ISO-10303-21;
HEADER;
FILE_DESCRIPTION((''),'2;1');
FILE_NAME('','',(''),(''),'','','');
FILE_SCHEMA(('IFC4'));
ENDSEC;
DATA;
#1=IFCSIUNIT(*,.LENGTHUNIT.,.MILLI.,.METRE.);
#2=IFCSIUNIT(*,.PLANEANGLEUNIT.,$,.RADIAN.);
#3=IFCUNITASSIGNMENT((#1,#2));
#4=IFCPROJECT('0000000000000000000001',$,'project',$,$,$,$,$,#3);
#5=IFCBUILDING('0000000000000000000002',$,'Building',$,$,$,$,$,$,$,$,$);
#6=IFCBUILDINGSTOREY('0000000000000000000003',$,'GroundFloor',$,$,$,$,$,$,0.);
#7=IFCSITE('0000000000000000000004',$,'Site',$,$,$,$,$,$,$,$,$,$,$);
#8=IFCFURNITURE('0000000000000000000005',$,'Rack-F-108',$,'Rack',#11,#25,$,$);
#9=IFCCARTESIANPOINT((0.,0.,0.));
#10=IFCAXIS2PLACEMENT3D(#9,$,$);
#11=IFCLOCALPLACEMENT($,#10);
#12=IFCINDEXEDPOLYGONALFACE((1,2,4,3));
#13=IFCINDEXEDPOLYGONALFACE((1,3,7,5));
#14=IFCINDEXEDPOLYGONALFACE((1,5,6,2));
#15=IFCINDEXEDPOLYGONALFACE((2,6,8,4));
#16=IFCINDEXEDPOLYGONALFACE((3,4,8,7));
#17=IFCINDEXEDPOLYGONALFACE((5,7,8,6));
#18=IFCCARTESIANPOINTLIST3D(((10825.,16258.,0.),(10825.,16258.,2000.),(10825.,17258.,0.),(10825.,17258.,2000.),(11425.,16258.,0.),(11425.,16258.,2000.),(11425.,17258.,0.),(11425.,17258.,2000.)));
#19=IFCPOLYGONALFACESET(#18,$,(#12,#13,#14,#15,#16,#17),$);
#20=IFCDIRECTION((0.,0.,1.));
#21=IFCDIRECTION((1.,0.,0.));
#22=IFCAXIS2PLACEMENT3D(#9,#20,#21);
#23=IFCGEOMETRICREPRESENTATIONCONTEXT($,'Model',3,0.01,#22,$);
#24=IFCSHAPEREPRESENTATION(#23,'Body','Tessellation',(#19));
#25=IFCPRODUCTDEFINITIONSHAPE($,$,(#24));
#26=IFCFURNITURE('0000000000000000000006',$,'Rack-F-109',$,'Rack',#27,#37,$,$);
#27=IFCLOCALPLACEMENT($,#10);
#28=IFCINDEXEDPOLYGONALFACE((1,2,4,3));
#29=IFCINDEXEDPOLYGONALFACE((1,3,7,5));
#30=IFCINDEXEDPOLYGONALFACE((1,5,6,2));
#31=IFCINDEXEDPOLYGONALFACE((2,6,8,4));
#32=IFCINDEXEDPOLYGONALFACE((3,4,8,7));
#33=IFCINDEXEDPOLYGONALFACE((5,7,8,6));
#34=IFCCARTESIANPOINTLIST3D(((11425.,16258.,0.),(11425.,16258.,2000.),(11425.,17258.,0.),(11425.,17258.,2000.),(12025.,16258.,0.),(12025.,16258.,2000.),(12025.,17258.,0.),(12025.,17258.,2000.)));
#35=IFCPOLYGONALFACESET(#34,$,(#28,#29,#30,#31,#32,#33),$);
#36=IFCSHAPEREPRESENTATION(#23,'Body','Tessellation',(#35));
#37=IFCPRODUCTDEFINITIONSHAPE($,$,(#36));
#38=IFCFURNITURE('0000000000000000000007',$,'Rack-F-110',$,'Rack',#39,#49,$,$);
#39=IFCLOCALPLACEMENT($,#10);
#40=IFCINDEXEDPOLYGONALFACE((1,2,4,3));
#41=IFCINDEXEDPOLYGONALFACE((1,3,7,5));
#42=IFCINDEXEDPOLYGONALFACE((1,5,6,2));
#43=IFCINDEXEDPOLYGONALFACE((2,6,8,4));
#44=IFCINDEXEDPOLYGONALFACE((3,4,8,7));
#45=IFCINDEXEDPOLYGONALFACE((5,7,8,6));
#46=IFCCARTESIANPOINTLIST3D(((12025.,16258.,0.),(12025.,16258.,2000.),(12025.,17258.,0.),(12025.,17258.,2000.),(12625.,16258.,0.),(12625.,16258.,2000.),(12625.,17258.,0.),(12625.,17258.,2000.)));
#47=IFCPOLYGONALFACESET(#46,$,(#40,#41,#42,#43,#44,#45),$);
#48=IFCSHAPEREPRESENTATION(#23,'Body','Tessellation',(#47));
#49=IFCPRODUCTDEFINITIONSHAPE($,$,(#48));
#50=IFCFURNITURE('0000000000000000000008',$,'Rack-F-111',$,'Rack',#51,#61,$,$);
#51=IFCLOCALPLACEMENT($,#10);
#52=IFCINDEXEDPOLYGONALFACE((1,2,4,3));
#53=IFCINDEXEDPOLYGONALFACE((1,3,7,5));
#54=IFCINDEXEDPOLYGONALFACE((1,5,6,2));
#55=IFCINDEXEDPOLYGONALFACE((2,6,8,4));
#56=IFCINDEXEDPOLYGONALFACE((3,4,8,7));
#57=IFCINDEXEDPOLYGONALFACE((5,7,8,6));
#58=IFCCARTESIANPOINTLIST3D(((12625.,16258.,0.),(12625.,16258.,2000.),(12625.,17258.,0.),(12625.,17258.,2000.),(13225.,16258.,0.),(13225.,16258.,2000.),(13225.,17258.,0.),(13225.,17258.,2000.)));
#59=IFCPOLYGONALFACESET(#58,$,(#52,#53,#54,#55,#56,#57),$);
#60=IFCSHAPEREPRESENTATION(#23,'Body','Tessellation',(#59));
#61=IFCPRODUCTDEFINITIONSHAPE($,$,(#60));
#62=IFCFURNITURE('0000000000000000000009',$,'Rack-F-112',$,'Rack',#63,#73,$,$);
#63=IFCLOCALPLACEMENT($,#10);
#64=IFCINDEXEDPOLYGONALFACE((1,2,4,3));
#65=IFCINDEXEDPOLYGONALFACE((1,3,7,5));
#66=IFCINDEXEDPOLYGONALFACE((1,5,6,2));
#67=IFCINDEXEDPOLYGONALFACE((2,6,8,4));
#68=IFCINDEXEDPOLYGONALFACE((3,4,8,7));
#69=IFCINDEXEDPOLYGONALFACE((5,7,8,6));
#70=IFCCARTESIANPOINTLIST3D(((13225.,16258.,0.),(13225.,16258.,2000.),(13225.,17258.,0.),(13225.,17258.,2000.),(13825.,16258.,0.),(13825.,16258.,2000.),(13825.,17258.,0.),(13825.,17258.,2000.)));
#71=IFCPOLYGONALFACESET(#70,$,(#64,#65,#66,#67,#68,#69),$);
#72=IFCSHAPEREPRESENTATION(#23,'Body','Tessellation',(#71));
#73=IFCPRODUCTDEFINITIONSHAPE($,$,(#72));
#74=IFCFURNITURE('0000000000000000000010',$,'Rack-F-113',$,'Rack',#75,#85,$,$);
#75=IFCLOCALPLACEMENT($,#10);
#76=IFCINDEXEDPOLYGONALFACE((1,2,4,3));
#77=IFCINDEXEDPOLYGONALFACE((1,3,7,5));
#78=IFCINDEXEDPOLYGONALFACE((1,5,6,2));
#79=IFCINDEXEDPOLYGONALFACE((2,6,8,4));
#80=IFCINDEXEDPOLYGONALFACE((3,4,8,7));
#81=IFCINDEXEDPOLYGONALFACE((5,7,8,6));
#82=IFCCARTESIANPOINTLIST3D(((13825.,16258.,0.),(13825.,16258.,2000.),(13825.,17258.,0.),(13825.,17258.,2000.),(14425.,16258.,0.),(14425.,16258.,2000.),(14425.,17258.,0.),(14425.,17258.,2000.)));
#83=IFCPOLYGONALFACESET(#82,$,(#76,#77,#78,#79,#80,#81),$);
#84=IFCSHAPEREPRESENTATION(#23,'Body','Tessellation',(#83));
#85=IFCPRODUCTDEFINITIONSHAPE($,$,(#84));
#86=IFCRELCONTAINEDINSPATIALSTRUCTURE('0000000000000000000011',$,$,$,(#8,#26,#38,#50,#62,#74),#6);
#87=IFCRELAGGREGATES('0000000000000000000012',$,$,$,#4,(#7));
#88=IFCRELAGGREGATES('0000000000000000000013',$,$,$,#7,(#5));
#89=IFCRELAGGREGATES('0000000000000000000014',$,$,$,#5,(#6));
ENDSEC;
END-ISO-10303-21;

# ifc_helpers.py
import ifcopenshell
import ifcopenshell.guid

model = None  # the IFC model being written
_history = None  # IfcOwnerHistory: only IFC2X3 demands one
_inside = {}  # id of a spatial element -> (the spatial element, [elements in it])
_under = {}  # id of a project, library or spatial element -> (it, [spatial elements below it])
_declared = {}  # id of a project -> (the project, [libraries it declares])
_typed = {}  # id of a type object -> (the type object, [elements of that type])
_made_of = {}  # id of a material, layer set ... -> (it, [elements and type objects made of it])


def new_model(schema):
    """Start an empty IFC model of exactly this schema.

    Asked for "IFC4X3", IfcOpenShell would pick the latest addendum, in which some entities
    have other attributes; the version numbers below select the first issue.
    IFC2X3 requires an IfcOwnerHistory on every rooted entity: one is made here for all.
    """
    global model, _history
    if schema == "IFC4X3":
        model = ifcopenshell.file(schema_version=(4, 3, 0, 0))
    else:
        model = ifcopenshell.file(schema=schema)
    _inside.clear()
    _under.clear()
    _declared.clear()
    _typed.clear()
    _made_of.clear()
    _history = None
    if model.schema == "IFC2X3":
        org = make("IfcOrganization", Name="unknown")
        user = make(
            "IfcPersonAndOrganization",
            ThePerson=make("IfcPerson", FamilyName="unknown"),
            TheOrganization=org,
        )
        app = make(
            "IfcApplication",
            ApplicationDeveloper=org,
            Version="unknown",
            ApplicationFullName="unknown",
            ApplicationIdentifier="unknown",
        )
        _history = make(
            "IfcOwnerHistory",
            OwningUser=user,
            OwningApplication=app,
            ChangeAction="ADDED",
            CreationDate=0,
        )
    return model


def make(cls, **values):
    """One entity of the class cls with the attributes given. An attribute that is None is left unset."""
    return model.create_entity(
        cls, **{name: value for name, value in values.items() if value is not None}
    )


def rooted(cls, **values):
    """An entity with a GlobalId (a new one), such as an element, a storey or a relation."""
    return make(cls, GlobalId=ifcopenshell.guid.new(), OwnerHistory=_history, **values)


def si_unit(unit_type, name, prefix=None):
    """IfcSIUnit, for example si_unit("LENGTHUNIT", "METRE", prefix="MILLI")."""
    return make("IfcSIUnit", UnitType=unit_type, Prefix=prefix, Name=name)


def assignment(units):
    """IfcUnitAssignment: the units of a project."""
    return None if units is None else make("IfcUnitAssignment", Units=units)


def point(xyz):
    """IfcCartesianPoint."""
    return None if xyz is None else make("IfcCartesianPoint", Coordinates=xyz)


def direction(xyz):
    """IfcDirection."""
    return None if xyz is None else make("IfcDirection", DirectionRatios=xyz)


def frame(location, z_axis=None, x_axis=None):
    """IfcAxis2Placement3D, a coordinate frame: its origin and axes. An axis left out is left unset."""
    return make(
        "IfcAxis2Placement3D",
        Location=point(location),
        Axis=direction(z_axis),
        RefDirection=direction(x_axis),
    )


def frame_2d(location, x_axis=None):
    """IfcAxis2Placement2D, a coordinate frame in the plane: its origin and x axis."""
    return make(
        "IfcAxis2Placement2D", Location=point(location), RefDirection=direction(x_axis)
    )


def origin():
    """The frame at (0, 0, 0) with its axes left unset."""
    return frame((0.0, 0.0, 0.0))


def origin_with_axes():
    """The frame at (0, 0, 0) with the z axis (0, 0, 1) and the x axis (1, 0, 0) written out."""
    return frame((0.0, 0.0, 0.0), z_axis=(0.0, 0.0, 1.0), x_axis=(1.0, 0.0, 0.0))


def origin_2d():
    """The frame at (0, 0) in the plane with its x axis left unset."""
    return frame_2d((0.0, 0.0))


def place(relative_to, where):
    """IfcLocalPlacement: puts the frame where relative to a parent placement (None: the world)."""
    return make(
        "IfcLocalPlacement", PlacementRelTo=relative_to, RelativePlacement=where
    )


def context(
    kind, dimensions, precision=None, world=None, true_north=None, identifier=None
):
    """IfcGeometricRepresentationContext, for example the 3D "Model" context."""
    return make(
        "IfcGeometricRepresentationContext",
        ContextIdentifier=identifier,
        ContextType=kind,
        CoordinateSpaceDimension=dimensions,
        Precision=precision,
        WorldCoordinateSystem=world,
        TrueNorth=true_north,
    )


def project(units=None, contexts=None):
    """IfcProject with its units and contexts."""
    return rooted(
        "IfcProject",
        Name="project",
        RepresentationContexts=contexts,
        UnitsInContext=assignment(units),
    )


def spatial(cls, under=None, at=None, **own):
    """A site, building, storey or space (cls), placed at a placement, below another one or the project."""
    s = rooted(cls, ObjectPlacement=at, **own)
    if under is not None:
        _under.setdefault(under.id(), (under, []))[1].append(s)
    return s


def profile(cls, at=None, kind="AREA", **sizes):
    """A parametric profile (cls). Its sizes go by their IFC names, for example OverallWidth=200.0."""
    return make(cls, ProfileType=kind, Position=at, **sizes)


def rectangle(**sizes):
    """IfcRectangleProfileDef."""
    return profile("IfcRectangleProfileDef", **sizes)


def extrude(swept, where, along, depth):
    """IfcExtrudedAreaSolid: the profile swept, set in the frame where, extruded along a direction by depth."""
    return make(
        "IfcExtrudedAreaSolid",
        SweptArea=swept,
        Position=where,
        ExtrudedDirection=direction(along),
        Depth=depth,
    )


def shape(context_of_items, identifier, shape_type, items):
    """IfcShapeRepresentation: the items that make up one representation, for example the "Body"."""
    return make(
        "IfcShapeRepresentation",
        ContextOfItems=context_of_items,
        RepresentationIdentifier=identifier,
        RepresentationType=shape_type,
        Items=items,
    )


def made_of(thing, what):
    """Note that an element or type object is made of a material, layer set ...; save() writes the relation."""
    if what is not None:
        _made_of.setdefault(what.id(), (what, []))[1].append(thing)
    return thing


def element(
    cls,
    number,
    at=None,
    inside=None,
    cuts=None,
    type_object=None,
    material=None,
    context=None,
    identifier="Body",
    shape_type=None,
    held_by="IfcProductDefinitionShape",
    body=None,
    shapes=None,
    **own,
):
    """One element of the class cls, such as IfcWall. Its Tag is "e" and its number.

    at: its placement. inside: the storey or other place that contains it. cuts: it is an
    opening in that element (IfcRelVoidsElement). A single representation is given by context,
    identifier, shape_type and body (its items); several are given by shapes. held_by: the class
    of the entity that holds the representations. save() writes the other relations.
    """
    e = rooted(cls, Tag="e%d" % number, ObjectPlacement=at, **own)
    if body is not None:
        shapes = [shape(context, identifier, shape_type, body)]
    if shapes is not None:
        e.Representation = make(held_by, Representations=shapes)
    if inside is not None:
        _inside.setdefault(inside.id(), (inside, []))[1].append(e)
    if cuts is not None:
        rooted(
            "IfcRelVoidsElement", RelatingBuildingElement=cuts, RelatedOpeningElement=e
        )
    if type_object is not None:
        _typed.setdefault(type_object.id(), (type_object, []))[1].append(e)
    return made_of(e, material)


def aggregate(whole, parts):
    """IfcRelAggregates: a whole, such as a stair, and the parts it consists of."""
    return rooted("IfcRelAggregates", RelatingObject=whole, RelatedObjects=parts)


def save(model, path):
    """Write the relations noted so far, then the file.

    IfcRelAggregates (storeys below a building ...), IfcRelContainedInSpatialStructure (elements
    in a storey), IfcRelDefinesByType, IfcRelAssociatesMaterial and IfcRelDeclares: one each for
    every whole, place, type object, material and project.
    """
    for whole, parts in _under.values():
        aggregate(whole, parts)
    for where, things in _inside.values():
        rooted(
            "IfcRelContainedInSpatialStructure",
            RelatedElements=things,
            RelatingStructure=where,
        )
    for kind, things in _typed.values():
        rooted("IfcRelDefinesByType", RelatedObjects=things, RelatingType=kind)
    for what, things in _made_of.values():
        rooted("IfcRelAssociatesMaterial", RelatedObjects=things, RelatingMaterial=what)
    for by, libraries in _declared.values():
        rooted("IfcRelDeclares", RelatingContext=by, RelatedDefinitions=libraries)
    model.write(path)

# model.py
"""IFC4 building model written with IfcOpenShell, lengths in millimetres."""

from ifc_helpers import new_model, si_unit, frame, origin, origin_with_axes, origin_2d, place, context, project, spatial, rectangle, extrude, element, save


model = new_model("IFC4")

# Units and contexts
model_context = context("Model", 3, precision=0.01, world=origin_with_axes())
ifc_project = project(units=[si_unit("LENGTHUNIT", "METRE", prefix="MILLI"), si_unit("PLANEANGLEUNIT", "RADIAN")])

# Site, building, storey
site = spatial("IfcSite", under=ifc_project, Name="Site")
building = spatial("IfcBuilding", under=site, Name="Building")
storey = spatial("IfcBuildingStorey", under=building, Name="GroundFloor", Elevation=0.0)

# Furniture
for number, where, z_axis, x_axis, name in (
    (1, (11125.0, 16758.0, 0.0), (0.0, 0.0, 1.0), (1.0, 0.0, 0.0), "Rack-F-108"),
    (2, (11725.0, 16758.0, 0.0), (0.0, 0.0, 1.0), (1.0, 0.0, 0.0), "Rack-F-109"),
    (3, (12325.0, 16758.0, 0.0), (0.0, 0.0, 1.0), (1.0, 0.0, 0.0), "Rack-F-110"),
    (4, (12925.0, 16758.0, 0.0), (0.0, 0.0, 1.0), (1.0, 0.0, 0.0), "Rack-F-111"),
    (5, (13525.0, 16758.0, 0.0), (0.0, 0.0, 1.0), (1.0, 0.0, 0.0), "Rack-F-112"),
    (6, (14125.0, 16758.0, 0.0), (0.0, 0.0, 1.0), (1.0, 0.0, 0.0), "Rack-F-113"),
):
    element("IfcFurniture", number, at=place(None, frame(where, z_axis=z_axis, x_axis=x_axis)), inside=storey, Name=name, ObjectType="Rack", context=model_context, shape_type="SweptSolid", body=[
        extrude(rectangle(XDim=600.0, YDim=1000.0, at=origin_2d()), origin(), (0.0, 0.0, 1.0), 2000.0),
    ])

save(model, "model.ifc")
